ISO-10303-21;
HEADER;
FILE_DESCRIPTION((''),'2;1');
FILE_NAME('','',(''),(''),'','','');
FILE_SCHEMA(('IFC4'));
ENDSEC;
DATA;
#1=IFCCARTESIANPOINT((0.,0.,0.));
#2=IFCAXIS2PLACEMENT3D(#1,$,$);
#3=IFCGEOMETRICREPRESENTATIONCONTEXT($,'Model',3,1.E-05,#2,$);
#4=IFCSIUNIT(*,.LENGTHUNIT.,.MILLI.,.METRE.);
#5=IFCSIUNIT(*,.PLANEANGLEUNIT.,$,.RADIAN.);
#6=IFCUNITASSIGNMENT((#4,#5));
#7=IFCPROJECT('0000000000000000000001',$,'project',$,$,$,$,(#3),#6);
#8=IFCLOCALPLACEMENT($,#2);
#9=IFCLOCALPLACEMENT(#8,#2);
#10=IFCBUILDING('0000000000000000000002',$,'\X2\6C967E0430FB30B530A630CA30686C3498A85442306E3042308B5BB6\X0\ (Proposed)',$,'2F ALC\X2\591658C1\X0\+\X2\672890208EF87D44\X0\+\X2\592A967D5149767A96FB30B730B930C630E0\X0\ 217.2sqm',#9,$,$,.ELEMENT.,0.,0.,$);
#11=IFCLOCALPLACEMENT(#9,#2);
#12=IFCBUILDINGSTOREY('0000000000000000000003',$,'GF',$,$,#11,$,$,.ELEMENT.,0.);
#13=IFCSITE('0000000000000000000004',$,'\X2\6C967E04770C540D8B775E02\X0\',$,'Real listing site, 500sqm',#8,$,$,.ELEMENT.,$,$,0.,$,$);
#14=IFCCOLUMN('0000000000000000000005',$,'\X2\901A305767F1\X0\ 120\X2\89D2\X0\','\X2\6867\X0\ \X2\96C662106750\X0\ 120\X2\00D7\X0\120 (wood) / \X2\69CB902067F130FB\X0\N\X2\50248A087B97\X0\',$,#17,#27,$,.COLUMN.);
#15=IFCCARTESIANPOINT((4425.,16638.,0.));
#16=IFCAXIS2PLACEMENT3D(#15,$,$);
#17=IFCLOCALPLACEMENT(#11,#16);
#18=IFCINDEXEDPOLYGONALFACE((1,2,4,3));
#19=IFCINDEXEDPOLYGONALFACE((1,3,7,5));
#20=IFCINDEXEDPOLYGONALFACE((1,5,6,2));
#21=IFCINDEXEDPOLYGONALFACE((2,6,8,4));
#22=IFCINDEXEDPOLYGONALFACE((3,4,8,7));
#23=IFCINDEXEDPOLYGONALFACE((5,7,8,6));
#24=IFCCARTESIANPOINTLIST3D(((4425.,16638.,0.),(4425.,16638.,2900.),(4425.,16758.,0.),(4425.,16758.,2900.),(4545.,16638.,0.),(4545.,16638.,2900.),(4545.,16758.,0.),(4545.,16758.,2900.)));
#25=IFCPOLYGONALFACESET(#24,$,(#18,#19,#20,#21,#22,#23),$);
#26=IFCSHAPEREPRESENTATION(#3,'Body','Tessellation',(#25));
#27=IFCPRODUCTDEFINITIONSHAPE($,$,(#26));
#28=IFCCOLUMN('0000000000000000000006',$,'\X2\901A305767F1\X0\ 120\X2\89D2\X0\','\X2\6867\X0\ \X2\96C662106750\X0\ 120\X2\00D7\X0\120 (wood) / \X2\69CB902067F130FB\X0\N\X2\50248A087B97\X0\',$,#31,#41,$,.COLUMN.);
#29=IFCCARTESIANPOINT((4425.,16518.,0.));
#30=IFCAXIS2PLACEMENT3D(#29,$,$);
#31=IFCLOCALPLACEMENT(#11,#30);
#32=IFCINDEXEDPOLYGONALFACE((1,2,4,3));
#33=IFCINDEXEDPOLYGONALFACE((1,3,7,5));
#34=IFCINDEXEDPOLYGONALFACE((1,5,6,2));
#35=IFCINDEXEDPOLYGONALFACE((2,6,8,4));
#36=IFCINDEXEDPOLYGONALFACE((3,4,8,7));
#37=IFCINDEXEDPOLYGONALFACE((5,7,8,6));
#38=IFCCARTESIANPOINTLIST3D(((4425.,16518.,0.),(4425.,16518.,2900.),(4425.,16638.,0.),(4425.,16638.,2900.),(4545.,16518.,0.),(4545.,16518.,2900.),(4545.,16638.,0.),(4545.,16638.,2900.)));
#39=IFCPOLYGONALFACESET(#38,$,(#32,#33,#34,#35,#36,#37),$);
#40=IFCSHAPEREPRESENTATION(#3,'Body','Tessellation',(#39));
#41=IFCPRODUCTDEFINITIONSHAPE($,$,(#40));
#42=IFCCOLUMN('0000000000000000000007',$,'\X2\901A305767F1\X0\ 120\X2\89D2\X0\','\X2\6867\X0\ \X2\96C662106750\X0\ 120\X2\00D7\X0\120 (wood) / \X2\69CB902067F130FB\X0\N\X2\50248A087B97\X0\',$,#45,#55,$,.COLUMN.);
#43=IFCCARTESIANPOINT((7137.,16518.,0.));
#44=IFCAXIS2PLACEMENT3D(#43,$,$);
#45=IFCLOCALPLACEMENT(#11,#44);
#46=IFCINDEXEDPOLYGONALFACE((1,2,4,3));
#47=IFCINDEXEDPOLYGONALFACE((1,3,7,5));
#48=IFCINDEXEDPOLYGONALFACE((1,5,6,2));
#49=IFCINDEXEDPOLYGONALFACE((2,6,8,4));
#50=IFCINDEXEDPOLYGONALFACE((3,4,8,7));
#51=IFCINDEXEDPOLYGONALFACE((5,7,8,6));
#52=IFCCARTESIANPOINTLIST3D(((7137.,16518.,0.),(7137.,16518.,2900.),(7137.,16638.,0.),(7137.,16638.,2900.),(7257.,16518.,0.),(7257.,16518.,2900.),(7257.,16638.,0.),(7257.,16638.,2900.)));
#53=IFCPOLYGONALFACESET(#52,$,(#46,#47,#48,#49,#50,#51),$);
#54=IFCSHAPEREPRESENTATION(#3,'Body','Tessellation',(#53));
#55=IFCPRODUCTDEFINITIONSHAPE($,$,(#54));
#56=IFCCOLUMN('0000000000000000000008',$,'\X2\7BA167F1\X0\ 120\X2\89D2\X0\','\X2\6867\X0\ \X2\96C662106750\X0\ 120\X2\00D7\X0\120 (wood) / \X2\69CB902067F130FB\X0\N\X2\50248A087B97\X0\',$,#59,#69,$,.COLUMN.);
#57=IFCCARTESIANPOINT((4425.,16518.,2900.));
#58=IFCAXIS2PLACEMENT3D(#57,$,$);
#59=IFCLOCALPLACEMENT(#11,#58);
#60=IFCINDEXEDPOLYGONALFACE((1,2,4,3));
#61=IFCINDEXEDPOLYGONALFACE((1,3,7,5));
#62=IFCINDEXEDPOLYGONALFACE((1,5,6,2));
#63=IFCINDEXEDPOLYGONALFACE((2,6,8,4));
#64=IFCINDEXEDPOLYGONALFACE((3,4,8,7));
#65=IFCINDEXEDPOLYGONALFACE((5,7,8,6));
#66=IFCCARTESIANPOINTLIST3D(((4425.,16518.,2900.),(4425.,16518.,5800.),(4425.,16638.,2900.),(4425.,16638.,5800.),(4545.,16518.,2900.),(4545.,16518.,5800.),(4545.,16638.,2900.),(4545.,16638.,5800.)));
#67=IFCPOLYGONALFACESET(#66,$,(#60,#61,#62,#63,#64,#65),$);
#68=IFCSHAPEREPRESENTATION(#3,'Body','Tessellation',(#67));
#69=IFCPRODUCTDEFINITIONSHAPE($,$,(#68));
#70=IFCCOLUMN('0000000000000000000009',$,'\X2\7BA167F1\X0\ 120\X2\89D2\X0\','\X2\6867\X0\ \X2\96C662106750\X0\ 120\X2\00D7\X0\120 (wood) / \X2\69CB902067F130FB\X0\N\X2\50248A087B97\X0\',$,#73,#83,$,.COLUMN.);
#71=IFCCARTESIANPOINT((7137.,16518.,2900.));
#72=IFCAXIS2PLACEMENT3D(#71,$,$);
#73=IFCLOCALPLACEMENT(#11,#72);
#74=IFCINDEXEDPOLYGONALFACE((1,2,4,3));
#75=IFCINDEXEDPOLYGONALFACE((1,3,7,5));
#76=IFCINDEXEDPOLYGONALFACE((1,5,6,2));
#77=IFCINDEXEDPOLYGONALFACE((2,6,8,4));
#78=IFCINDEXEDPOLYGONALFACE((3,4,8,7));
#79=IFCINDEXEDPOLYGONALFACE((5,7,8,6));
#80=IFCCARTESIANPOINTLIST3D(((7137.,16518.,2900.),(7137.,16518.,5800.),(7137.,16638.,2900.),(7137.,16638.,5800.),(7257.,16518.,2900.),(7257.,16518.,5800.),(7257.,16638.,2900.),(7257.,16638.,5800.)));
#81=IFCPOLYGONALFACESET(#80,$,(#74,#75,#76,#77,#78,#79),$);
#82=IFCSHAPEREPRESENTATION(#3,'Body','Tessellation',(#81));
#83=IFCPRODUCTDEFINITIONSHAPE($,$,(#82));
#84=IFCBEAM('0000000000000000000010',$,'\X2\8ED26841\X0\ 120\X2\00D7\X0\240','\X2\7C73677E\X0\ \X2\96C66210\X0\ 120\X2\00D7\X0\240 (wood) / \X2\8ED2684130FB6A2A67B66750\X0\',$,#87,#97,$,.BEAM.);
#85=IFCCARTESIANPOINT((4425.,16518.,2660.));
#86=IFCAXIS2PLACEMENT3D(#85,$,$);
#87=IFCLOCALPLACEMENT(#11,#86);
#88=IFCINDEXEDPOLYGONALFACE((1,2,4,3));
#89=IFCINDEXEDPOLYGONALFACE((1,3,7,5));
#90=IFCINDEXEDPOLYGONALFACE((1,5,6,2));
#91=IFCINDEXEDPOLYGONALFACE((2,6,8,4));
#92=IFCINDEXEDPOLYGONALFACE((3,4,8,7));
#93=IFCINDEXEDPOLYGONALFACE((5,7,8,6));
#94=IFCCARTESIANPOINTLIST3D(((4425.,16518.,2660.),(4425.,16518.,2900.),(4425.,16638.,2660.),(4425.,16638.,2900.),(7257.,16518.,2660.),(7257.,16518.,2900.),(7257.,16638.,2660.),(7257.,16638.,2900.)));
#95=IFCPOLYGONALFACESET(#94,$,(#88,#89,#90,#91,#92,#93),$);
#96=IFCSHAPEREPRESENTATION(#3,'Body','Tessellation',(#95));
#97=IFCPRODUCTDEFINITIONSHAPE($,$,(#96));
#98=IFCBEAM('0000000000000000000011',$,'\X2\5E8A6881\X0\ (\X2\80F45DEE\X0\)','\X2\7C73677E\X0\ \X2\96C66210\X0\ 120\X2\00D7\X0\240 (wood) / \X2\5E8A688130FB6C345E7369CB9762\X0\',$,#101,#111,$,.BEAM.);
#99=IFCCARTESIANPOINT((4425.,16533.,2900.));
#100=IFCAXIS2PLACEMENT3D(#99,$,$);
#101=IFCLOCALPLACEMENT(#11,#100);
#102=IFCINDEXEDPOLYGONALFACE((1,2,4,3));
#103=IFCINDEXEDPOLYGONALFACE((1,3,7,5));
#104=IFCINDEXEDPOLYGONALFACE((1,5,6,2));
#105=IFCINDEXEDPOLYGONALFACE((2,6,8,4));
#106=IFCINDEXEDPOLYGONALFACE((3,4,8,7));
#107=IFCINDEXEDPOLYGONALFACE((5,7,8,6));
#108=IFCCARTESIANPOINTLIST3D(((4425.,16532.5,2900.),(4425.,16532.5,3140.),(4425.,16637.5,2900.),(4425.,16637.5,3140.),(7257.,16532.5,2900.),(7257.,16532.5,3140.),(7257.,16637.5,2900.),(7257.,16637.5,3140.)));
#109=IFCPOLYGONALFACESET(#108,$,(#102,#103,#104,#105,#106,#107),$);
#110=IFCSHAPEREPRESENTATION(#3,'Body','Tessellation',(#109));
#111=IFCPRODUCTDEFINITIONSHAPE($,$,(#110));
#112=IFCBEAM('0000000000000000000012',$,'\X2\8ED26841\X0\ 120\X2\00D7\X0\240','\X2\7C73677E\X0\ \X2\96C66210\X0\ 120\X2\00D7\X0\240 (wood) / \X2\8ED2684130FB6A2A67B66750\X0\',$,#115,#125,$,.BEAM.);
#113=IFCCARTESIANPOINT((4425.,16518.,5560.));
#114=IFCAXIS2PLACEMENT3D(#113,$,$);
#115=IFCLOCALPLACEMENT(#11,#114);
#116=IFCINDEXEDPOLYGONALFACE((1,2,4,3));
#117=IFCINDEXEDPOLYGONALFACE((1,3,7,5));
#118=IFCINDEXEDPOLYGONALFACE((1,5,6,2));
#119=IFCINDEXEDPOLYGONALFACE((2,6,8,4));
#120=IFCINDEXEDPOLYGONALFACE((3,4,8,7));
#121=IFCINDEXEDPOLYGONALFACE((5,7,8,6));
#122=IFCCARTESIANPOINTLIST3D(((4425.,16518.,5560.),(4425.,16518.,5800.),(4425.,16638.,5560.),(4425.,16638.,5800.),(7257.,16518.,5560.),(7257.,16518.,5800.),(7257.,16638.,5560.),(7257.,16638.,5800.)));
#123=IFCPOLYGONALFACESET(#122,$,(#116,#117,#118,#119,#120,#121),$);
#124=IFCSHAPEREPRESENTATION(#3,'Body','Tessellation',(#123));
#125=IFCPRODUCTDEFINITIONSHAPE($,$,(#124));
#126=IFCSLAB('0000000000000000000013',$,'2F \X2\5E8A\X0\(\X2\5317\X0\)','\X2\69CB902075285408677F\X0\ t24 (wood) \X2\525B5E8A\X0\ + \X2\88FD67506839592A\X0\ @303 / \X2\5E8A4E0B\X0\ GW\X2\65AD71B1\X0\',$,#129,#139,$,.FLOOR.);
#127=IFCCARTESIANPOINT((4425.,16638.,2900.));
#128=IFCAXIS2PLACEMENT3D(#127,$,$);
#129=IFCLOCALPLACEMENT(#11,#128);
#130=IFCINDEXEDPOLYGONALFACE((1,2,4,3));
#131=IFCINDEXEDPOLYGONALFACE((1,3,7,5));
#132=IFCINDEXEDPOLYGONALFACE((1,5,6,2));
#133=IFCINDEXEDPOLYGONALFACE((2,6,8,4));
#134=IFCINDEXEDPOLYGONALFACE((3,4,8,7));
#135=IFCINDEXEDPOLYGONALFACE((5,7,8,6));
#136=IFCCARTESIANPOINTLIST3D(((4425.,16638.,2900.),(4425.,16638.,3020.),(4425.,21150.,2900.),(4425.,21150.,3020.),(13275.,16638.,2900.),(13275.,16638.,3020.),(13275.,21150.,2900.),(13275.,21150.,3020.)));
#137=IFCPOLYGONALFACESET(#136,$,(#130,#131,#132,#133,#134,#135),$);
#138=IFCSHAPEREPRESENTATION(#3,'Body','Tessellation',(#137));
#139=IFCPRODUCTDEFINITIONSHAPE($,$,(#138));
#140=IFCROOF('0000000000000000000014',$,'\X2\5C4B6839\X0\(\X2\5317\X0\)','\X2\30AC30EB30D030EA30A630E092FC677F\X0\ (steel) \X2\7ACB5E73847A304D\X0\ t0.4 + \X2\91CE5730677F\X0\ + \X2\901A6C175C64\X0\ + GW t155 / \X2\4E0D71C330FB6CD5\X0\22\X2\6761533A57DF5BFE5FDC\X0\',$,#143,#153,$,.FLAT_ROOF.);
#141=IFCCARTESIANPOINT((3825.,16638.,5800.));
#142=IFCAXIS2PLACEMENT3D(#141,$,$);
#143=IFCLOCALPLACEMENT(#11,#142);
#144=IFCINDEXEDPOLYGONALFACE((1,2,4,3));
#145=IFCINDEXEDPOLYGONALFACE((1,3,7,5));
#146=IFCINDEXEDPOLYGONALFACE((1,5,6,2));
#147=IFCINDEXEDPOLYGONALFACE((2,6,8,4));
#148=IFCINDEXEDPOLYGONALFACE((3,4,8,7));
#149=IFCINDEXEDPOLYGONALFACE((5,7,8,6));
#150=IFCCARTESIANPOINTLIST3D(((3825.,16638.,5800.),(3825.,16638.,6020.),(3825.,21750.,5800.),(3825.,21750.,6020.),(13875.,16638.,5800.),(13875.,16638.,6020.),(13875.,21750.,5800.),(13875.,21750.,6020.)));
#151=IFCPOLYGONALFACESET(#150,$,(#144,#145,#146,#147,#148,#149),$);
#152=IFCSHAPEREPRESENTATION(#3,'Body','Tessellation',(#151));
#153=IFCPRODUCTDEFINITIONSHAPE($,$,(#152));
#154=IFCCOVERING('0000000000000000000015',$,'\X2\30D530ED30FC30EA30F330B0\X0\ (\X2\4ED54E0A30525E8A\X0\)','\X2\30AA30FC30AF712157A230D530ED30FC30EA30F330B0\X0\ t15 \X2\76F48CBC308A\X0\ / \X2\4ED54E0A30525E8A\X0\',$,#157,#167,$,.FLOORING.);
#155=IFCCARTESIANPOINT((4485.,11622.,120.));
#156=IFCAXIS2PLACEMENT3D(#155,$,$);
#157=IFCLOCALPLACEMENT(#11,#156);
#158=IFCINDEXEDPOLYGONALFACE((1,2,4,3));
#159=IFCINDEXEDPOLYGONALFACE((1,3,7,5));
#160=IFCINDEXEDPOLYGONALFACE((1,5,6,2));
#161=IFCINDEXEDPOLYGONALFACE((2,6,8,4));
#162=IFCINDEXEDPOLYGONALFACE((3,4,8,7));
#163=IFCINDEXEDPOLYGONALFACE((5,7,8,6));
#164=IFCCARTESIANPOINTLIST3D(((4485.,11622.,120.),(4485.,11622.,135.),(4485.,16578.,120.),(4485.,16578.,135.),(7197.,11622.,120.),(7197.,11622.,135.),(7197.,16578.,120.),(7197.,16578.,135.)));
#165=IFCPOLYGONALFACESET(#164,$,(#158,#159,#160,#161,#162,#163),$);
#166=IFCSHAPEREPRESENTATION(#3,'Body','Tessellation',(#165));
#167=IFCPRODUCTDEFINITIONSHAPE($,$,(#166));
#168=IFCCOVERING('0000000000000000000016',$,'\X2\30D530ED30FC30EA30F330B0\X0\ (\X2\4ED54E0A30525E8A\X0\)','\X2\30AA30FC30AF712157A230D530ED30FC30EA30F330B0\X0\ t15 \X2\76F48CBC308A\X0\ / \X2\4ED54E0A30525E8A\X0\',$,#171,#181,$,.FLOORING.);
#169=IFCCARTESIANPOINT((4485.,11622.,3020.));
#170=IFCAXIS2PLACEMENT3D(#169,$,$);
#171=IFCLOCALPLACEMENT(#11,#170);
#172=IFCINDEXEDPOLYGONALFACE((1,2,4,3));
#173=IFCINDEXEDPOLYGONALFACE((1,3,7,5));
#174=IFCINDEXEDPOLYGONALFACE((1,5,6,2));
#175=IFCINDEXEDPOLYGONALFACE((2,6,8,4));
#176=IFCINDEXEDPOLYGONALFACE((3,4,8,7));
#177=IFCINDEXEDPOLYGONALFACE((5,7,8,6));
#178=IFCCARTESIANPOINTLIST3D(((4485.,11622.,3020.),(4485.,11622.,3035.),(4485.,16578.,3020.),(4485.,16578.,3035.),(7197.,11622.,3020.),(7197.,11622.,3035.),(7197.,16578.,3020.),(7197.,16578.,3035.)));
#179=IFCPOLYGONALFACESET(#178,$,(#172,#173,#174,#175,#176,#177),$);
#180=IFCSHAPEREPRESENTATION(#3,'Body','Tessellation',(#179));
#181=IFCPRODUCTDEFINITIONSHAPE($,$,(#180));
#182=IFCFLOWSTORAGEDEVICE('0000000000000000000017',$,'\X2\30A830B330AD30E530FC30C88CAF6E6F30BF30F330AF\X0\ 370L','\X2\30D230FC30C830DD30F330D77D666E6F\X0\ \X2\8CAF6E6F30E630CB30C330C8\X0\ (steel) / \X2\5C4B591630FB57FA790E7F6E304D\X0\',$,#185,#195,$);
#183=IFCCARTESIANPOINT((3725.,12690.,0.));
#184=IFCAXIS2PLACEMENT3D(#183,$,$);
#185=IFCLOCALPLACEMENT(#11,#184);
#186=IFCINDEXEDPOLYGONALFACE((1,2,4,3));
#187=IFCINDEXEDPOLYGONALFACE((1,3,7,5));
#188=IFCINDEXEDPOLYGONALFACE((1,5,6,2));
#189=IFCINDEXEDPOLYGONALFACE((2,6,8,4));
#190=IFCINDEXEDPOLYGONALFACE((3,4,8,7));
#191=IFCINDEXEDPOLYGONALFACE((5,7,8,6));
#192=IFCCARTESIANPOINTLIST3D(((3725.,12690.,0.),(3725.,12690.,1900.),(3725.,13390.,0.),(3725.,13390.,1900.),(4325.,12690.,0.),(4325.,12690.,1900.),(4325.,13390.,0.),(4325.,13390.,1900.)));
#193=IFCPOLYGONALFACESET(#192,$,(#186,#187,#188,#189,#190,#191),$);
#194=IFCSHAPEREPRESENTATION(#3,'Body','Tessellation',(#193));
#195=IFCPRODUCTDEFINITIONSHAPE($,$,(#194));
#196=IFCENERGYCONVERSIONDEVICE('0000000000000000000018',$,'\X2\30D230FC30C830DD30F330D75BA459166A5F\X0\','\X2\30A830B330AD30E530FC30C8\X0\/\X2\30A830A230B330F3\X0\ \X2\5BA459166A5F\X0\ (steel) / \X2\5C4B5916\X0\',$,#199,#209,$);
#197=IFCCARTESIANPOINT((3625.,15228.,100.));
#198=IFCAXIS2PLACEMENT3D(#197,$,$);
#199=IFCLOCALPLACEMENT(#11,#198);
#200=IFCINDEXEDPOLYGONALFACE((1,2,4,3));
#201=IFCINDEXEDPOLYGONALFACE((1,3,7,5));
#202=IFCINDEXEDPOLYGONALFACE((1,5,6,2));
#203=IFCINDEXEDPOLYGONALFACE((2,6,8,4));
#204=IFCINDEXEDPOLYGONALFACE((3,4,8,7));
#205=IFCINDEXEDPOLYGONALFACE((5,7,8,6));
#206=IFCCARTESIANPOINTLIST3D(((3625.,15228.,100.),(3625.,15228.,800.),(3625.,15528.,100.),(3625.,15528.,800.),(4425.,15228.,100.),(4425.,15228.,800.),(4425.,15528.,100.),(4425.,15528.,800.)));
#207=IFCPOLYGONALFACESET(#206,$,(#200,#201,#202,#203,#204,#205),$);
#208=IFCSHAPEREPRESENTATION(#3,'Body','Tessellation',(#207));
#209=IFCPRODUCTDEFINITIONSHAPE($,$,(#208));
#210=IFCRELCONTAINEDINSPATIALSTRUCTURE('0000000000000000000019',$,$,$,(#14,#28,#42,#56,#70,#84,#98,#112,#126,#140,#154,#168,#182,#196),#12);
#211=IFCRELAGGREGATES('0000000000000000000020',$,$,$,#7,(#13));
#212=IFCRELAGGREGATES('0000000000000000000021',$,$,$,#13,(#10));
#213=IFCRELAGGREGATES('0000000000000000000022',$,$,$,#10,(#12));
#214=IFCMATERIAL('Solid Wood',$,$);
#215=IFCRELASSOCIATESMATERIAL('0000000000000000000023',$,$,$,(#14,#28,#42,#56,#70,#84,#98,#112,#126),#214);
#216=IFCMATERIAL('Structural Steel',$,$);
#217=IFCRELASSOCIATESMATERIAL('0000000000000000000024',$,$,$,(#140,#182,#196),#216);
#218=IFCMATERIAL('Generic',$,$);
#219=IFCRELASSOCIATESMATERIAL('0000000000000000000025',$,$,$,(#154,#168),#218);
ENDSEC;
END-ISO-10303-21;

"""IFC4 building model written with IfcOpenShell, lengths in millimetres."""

from ifc_helpers import new_model, si_unit, frame, frame_2d, origin, place, context, project, spatial, rectangle, extrude, material, element, save


model = new_model("IFC4")

# Units and contexts
model_context = context("Model", 3, precision=1e-05, world=origin())
ifc_project = project(units=[si_unit("LENGTHUNIT", "METRE", prefix="MILLI"), si_unit("PLANEANGLEUNIT", "RADIAN")], contexts=[model_context])

# Site, building, storey
site_placement = place(None, origin())
site = spatial("IfcSite", under=ifc_project, at=site_placement, Name="沖縄県名護市", ObjectType="Real listing site, 500sqm", CompositionType="ELEMENT", RefElevation=0.0)
building_placement = place(site_placement, origin())
building = spatial("IfcBuilding", under=site, at=building_placement, Name="沖縄・サウナと水風呂のある家 (Proposed)", ObjectType="2F ALC外壁+木造軸組+太陽光発電システム 217.2sqm", CompositionType="ELEMENT", ElevationOfRefHeight=0.0, ElevationOfTerrain=0.0)
storey_placement = place(building_placement, origin())
storey = spatial("IfcBuildingStorey", under=building, at=storey_placement, Name="GF", CompositionType="ELEMENT", Elevation=0.0)

# Columns
ifc_material_1 = material(Name="Solid Wood")
column_1_placement = place(storey_placement, frame((4425.0, 16638.0, 0.0)))
element("IfcColumn", 1, at=column_1_placement, inside=storey, material=ifc_material_1, Name="通し柱 120角", Description="桧 集成材 120×120 (wood) / 構造柱・N値計算", PredefinedType="COLUMN", context=model_context, shape_type="SweptSolid", body=[
    extrude(rectangle(XDim=120.0, YDim=120.0, at=frame_2d((60.0, 60.0))), frame((4425.0, 16638.0, 0.0)), (0.0, 0.0, 1.0), 2900.0),
])
column_2_placement = place(storey_placement, frame((4425.0, 16518.0, 0.0)))
element("IfcColumn", 2, at=column_2_placement, inside=storey, material=ifc_material_1, Name="通し柱 120角", Description="桧 集成材 120×120 (wood) / 構造柱・N値計算", PredefinedType="COLUMN", context=model_context, shape_type="SweptSolid", body=[
    extrude(rectangle(XDim=120.0, YDim=120.0, at=frame_2d((60.0, 60.0))), frame((4425.0, 16518.0, 0.0)), (0.0, 0.0, 1.0), 2900.0),
])
column_3_placement = place(storey_placement, frame((7137.0, 16518.0, 0.0)))
element("IfcColumn", 3, at=column_3_placement, inside=storey, material=ifc_material_1, Name="通し柱 120角", Description="桧 集成材 120×120 (wood) / 構造柱・N値計算", PredefinedType="COLUMN", context=model_context, shape_type="SweptSolid", body=[
    extrude(rectangle(XDim=120.0, YDim=120.0, at=frame_2d((60.0, 60.0))), frame((7137.0, 16518.0, 0.0)), (0.0, 0.0, 1.0), 2900.0),
])
column_4_placement = place(storey_placement, frame((4425.0, 16518.0, 2900.0)))
element("IfcColumn", 4, at=column_4_placement, inside=storey, material=ifc_material_1, Name="管柱 120角", Description="桧 集成材 120×120 (wood) / 構造柱・N値計算", PredefinedType="COLUMN", context=model_context, shape_type="SweptSolid", body=[
    extrude(rectangle(XDim=120.0, YDim=120.0, at=frame_2d((60.0, 60.0))), frame((4425.0, 16518.0, 2900.0)), (0.0, 0.0, 1.0), 2900.0),
])
column_5_placement = place(storey_placement, frame((7137.0, 16518.0, 2900.0)))
element("IfcColumn", 5, at=column_5_placement, inside=storey, material=ifc_material_1, Name="管柱 120角", Description="桧 集成材 120×120 (wood) / 構造柱・N値計算", PredefinedType="COLUMN", context=model_context, shape_type="SweptSolid", body=[
    extrude(rectangle(XDim=120.0, YDim=120.0, at=frame_2d((60.0, 60.0))), frame((7137.0, 16518.0, 2900.0)), (0.0, 0.0, 1.0), 2900.0),
])

# Beams
beam_1_placement = place(storey_placement, frame((4425.0, 16518.0, 2660.0)))
element("IfcBeam", 6, at=beam_1_placement, inside=storey, material=ifc_material_1, Name="軒桁 120×240", Description="米松 集成 120×240 (wood) / 軒桁・横架材", PredefinedType="BEAM", context=model_context, shape_type="SweptSolid", body=[
    extrude(rectangle(XDim=2832.0, YDim=120.0, at=frame_2d((1416.0, 60.0))), frame((4425.0, 16518.0, 2660.0)), (0.0, 0.0, 1.0), 240.0),
])
beam_2_placement = place(storey_placement, frame((4425.0, 16533.0, 2900.0)))
element("IfcBeam", 7, at=beam_2_placement, inside=storey, material=ifc_material_1, Name="床梁 (胴差)", Description="米松 集成 120×240 (wood) / 床梁・水平構面", PredefinedType="BEAM", context=model_context, shape_type="SweptSolid", body=[
    extrude(rectangle(XDim=2832.0, YDim=105.0, at=frame_2d((1416.0, 52.0))), frame((4425.0, 16533.0, 2900.0)), (0.0, 0.0, 1.0), 240.0),
])
beam_3_placement = place(storey_placement, frame((4425.0, 16518.0, 5560.0)))
element("IfcBeam", 8, at=beam_3_placement, inside=storey, material=ifc_material_1, Name="軒桁 120×240", Description="米松 集成 120×240 (wood) / 軒桁・横架材", PredefinedType="BEAM", context=model_context, shape_type="SweptSolid", body=[
    extrude(rectangle(XDim=2832.0, YDim=120.0, at=frame_2d((1416.0, 60.0))), frame((4425.0, 16518.0, 5560.0)), (0.0, 0.0, 1.0), 240.0),
])

# Slab
slab_1_placement = place(storey_placement, frame((4425.0, 16638.0, 2900.0)))
element("IfcSlab", 9, at=slab_1_placement, inside=storey, material=ifc_material_1, Name="2F 床(北)", Description="構造用合板 t24 (wood) 剛床 + 製材根太 @303 / 床下 GW断熱", PredefinedType="FLOOR", context=model_context, shape_type="SweptSolid", body=[
    extrude(rectangle(XDim=8850.0, YDim=4512.0, at=frame_2d((4425.0, 2256.0))), frame((4425.0, 16638.0, 2900.0)), (0.0, 0.0, 1.0), 120.0),
])

# Roof
ifc_material_2 = material(Name="Structural Steel")
for number, where, name in (
    (10, (3825.0, 16638.0, 5800.0), "屋根(北)"),
):
    element("IfcRoof", number, at=place(storey_placement, frame(where)), inside=storey, material=ifc_material_2, Name=name, Description="ガルバリウム鋼板 (steel) 立平葺き t0.4 + 野地板 + 通気層 + GW t155 / 不燃・法22条区域対応", PredefinedType="FLAT_ROOF", context=model_context, shape_type="SweptSolid", body=[
        extrude(rectangle(XDim=10050.0, YDim=5112.0, at=frame_2d((5025.0, 2556.0))), frame((3825.0, 16638.0, 5800.0)), (0.0, 0.0, 1.0), 220.0),
    ])

# Coverings
ifc_material_3 = material(Name="Generic")
covering_1_placement = place(storey_placement, frame((4485.0, 11622.0, 120.0)))
element("IfcCovering", 11, at=covering_1_placement, inside=storey, material=ifc_material_3, Name="フローリング (仕上げ床)", Description="オーク無垢フローリング t15 直貼り / 仕上げ床", PredefinedType="FLOORING", context=model_context, shape_type="SweptSolid", body=[
    extrude(rectangle(XDim=2712.0, YDim=4956.0, at=frame_2d((1356.0, 2478.0))), frame((4485.0, 11622.0, 120.0)), (0.0, 0.0, 1.0), 15.0),
])
covering_2_placement = place(storey_placement, frame((4485.0, 11622.0, 3020.0)))
element("IfcCovering", 12, at=covering_2_placement, inside=storey, material=ifc_material_3, Name="フローリング (仕上げ床)", Description="オーク無垢フローリング t15 直貼り / 仕上げ床", PredefinedType="FLOORING", context=model_context, shape_type="SweptSolid", body=[
    extrude(rectangle(XDim=2712.0, YDim=4956.0, at=frame_2d((1356.0, 2478.0))), frame((4485.0, 11622.0, 3020.0)), (0.0, 0.0, 1.0), 15.0),
])

# Flow storage device
flow_storage_device_placement = place(storey_placement, frame((3725.0, 12690.0, 0.0)))
element("IfcFlowStorageDevice", 13, at=flow_storage_device_placement, inside=storey, material=ifc_material_2, Name="エコキュート貯湯タンク 370L", Description="ヒートポンプ給湯 貯湯ユニット (steel) / 屋外・基礎置き", context=model_context, shape_type="SweptSolid", body=[
    extrude(rectangle(XDim=600.0, YDim=700.0, at=frame_2d((300.0, 350.0))), frame((3725.0, 12690.0, 0.0)), (0.0, 0.0, 1.0), 1900.0),
])

# Energy conversion device
energy_conversion_device_placement = place(storey_placement, frame((3625.0, 15228.0, 100.0)))
element("IfcEnergyConversionDevice", 14, at=energy_conversion_device_placement, inside=storey, material=ifc_material_2, Name="ヒートポンプ室外機", Description="エコキュート/エアコン 室外機 (steel) / 屋外", context=model_context, shape_type="SweptSolid", body=[
    extrude(rectangle(XDim=800.0, YDim=300.0, at=frame_2d((400.0, 150.0))), frame((3625.0, 15228.0, 100.0)), (0.0, 0.0, 1.0), 700.0),
])

save(model, "model.ifc")
